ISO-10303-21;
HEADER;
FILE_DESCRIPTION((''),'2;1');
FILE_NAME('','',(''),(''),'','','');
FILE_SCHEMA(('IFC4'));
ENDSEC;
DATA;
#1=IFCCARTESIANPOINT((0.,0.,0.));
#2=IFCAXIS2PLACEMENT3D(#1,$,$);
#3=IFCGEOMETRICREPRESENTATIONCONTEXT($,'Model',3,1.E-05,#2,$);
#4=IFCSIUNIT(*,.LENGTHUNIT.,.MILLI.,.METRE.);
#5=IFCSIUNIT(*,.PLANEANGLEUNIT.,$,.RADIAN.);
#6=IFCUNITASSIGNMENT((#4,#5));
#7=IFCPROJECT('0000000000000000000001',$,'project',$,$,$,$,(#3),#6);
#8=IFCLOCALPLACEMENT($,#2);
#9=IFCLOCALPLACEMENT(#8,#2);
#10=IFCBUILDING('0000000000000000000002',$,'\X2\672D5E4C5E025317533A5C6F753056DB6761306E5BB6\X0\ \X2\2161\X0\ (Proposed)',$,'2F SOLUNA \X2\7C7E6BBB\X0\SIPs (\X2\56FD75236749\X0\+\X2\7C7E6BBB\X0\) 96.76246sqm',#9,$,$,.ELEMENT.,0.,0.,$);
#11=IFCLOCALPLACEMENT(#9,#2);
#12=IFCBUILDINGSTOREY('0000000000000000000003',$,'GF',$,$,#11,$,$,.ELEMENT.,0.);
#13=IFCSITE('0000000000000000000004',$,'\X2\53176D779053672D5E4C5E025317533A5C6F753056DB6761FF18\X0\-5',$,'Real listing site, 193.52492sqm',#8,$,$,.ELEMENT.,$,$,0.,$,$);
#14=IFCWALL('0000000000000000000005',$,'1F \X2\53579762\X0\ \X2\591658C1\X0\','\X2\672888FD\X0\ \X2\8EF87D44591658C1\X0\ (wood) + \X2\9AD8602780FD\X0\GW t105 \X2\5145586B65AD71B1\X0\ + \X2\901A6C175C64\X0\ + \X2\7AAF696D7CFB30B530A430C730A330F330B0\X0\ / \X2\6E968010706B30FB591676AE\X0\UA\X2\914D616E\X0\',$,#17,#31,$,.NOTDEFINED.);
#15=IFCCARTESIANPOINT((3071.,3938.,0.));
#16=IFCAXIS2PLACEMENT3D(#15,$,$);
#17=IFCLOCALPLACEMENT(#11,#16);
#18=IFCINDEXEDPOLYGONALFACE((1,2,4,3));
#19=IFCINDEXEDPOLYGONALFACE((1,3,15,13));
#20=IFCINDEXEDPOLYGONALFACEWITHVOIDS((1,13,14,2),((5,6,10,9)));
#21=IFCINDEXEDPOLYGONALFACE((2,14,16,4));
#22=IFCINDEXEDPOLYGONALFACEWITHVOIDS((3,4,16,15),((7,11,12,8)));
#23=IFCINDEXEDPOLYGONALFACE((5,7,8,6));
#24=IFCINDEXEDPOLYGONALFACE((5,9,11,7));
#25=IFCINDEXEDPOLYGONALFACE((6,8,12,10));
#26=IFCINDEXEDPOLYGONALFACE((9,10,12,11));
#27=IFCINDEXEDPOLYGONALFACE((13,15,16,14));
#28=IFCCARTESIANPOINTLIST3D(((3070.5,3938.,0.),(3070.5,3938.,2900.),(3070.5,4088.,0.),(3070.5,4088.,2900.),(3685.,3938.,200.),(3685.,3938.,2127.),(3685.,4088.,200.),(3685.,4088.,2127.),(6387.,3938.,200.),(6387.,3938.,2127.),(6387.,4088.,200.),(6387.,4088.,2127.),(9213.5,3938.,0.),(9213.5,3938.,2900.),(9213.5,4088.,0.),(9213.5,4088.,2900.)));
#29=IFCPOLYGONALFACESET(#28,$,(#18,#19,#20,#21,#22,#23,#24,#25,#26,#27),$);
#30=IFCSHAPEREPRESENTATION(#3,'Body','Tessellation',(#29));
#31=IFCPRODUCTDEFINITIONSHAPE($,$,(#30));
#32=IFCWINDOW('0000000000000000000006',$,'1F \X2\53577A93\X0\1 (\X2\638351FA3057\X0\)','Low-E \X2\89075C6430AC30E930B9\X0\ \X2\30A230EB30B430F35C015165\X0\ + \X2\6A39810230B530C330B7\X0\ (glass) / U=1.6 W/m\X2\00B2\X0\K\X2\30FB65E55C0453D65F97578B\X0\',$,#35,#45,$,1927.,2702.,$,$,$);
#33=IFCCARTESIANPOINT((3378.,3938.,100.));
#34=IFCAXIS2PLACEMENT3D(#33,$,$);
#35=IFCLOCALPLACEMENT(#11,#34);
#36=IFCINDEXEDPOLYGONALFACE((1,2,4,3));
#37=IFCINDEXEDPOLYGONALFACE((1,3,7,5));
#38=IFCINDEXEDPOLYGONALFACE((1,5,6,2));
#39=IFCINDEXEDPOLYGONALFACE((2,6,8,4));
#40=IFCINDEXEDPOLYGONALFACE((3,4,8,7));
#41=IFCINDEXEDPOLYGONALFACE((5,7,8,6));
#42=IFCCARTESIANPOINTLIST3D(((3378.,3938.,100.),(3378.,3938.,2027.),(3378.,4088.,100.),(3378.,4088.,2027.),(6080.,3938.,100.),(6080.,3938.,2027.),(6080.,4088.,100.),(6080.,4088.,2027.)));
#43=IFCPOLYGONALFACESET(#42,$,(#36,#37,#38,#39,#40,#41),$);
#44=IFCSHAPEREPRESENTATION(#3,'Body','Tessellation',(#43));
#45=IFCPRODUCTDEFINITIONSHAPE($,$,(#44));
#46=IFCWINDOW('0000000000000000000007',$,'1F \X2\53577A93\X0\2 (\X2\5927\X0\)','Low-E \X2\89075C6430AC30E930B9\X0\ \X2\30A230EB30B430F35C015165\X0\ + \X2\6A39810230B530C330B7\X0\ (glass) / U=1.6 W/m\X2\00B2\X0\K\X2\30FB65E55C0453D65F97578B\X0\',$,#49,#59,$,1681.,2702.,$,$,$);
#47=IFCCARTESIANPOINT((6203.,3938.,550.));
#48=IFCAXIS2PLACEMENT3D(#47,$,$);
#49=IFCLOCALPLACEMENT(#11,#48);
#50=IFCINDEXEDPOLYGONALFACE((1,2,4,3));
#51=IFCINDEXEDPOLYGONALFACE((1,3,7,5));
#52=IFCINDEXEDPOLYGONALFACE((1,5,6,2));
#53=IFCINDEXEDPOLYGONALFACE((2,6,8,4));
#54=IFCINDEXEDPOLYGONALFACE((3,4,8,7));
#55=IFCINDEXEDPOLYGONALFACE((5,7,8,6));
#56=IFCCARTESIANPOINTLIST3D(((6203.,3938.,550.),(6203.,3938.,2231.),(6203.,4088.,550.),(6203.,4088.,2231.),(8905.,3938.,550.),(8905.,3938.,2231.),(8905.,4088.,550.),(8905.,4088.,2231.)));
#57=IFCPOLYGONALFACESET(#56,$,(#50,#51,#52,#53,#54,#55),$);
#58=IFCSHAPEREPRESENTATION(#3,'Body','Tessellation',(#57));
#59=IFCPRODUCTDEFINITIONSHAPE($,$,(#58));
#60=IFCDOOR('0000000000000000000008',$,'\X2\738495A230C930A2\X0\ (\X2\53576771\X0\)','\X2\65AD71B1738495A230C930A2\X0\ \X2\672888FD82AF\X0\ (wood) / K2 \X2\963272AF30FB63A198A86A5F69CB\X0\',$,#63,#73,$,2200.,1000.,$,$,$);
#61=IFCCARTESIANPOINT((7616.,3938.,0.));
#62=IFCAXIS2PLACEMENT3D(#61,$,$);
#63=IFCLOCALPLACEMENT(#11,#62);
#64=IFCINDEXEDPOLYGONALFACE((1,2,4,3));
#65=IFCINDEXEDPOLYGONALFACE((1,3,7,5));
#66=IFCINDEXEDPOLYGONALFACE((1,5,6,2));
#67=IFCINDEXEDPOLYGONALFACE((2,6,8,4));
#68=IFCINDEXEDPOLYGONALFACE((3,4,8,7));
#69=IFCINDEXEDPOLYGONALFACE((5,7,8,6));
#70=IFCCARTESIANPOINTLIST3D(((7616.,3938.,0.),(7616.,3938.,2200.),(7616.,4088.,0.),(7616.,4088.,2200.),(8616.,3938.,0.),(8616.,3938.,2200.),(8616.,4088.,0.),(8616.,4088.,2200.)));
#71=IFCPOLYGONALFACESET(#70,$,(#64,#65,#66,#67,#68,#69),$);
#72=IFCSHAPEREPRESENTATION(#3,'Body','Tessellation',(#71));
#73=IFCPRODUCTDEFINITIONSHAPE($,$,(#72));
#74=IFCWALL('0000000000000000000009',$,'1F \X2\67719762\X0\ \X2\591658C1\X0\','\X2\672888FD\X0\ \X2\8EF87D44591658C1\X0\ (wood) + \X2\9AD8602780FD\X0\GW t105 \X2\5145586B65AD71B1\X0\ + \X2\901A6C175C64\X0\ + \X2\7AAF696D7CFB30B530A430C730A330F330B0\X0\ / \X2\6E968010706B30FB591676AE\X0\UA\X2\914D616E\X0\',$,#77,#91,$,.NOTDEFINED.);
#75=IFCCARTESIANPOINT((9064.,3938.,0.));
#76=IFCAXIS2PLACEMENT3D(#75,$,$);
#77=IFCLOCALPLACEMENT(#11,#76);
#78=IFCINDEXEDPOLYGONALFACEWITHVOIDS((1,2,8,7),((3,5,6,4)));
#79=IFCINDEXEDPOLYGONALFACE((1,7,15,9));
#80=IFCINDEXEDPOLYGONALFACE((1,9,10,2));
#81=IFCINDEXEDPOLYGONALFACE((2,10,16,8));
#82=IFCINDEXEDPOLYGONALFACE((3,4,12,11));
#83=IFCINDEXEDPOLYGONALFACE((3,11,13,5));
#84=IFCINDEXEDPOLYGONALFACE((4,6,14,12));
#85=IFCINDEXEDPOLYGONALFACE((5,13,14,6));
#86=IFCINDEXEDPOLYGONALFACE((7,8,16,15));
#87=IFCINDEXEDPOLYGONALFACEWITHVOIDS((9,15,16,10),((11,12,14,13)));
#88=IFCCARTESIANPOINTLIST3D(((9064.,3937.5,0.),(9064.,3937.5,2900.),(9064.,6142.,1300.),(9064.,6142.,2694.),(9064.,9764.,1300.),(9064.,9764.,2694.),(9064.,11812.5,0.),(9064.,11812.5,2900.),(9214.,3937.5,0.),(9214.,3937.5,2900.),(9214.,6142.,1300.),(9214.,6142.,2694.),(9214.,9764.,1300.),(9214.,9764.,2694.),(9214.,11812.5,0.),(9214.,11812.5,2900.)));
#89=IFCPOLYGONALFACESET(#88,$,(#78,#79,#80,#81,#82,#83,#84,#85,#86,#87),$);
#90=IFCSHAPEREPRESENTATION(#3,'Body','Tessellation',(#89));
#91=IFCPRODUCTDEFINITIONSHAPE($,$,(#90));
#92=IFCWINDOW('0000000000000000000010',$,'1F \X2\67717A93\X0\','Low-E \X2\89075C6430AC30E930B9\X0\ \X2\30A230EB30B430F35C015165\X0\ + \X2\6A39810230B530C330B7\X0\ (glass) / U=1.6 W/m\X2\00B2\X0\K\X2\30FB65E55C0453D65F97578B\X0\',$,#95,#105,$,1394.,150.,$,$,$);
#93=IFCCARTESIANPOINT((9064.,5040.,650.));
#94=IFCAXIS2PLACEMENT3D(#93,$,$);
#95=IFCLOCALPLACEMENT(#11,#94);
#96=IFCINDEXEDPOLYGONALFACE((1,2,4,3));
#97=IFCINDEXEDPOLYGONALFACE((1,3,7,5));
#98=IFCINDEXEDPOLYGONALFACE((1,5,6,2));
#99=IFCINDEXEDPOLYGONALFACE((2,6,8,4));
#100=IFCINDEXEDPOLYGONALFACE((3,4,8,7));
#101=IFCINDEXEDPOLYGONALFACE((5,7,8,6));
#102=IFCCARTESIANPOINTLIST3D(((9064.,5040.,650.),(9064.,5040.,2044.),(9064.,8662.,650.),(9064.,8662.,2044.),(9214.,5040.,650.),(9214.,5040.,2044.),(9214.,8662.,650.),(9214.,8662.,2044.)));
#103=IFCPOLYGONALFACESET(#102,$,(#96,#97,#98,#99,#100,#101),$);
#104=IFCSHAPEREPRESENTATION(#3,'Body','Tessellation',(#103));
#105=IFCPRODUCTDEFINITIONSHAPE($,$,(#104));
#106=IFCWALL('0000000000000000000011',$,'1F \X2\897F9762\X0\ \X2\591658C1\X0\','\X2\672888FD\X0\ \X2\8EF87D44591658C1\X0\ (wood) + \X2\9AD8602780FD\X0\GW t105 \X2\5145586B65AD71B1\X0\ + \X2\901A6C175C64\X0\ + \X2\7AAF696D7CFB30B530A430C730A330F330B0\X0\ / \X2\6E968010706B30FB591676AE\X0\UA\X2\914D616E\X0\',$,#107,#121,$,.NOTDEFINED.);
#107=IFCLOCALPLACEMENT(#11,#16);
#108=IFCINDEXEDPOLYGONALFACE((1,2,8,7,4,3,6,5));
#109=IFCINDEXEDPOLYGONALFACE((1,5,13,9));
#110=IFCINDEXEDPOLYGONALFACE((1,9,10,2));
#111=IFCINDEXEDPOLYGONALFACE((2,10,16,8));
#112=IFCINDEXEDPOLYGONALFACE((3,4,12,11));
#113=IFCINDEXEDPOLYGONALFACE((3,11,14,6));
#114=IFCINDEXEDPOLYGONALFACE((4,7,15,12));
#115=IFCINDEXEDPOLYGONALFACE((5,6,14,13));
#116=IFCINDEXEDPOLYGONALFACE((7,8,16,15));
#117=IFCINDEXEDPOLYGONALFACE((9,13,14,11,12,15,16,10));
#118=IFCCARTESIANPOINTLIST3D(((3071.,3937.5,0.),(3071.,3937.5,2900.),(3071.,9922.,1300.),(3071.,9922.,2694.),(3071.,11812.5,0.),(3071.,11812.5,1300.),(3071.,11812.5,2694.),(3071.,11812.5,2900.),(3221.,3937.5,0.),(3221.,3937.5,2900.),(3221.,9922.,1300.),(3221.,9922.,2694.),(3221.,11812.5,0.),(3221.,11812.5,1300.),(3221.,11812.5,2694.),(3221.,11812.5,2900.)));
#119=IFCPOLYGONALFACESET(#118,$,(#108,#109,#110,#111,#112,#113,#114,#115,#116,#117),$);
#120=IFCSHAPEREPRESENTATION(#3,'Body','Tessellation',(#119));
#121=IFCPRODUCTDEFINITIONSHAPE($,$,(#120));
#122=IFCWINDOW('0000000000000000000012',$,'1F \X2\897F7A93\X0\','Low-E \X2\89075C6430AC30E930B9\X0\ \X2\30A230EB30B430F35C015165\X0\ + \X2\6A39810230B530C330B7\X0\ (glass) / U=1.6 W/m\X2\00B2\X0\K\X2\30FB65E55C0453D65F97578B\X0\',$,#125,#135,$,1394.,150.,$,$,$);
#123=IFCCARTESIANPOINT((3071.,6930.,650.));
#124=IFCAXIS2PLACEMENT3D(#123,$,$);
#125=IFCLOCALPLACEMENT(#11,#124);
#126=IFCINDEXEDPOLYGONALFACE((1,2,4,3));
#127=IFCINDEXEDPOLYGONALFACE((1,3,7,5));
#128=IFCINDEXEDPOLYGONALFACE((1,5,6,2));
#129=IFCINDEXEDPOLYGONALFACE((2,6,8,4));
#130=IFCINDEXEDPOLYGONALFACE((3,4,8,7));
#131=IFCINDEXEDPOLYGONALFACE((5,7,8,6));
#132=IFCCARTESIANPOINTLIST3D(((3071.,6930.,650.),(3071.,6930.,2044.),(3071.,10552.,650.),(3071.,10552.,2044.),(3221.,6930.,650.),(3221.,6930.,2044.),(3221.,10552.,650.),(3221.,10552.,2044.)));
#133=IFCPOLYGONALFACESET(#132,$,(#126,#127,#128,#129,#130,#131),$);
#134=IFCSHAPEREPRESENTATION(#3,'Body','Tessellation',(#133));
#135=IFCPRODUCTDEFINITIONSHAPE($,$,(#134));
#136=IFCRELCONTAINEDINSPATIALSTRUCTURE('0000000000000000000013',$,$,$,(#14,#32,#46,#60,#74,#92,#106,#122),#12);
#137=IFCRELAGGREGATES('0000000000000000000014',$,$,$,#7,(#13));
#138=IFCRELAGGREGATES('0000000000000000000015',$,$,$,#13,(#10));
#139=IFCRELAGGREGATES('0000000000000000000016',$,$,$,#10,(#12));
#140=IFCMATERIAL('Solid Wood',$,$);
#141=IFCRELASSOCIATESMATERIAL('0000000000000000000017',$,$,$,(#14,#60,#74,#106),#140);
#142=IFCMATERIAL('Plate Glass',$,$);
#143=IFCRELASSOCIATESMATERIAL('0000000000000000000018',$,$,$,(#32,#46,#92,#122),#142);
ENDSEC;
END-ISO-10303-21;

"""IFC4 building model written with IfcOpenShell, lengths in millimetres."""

from ifc_helpers import new_model, si_unit, frame, frame_2d, origin, place, context, project, spatial, rectangle, extrude, material, element, fill, save


model = new_model("IFC4")

# Units and contexts
model_context = context("Model", 3, precision=1e-05, world=origin())
ifc_project = project(units=[si_unit("LENGTHUNIT", "METRE", prefix="MILLI"), si_unit("PLANEANGLEUNIT", "RADIAN")], contexts=[model_context])

# Site, building, storey
site_placement = place(None, origin())
site = spatial("IfcSite", under=ifc_project, at=site_placement, Name="北海道札幌市北区屯田四条８-5", ObjectType="Real listing site, 193.52492sqm", CompositionType="ELEMENT", RefElevation=0.0)
building_placement = place(site_placement, origin())
building = spatial("IfcBuilding", under=site, at=building_placement, Name="札幌市北区屯田四条の家 Ⅱ (Proposed)", ObjectType="2F SOLUNA 籾殻SIPs (国産杉+籾殻) 96.76246sqm", CompositionType="ELEMENT", ElevationOfRefHeight=0.0, ElevationOfTerrain=0.0)
storey_placement = place(building_placement, origin())
storey = spatial("IfcBuildingStorey", under=building, at=storey_placement, Name="GF", CompositionType="ELEMENT", Elevation=0.0)

# Shared definitions
ifc_material_1 = material(Name="Solid Wood")

# Wall, openings, windows, door
wall_1_placement = place(storey_placement, frame((3071.0, 3938.0, 0.0)))
wall_1 = element("IfcWall", 1, at=wall_1_placement, inside=storey, material=ifc_material_1, Name="1F 南面 外壁", Description="木製 軸組外壁 (wood) + 高性能GW t105 充填断熱 + 通気層 + 窯業系サイディング / 準耐火・外皮UA配慮", PredefinedType="NOTDEFINED", context=model_context, shape_type="SweptSolid", body=[
    extrude(rectangle(XDim=6143.0, YDim=150.0, at=frame_2d((3071.0, 75.0))), frame((3071.0, 3938.0, 0.0)), (0.0, 0.0, 1.0), 2900.0),
])
opening_1_placement = place(storey_placement, frame((3378.0, 3938.0, 100.0)))
opening_1 = element("IfcOpeningElement", 2, at=opening_1_placement, cuts=wall_1, PredefinedType="NOTDEFINED", context=model_context, shape_type="SweptSolid", body=[
    extrude(rectangle(XDim=2702.0, YDim=150.0, at=frame_2d((1351.0, 75.0))), frame((3378.0, 3938.0, 100.0)), (0.0, 0.0, 1.0), 1927.0),
])
opening_2_placement = place(storey_placement, frame((6203.0, 3938.0, 550.0)))
opening_2 = element("IfcOpeningElement", 3, at=opening_2_placement, cuts=wall_1, PredefinedType="NOTDEFINED", context=model_context, shape_type="SweptSolid", body=[
    extrude(rectangle(XDim=2702.0, YDim=150.0, at=frame_2d((1351.0, 75.0))), frame((6203.0, 3938.0, 550.0)), (0.0, 0.0, 1.0), 1681.0),
])
opening_3_placement = place(storey_placement, frame((7616.0, 3938.0, 0.0)))
opening_3 = element("IfcOpeningElement", 4, at=opening_3_placement, cuts=wall_1, PredefinedType="NOTDEFINED", context=model_context, shape_type="SweptSolid", body=[
    extrude(rectangle(XDim=1000.0, YDim=150.0, at=frame_2d((500.0, 75.0))), frame((7616.0, 3938.0, 0.0)), (0.0, 0.0, 1.0), 2200.0),
])
ifc_material_2 = material(Name="Plate Glass")
window_1_placement = place(storey_placement, frame((3378.0, 3938.0, 100.0)))
window_1 = element("IfcWindow", 5, at=window_1_placement, inside=storey, material=ifc_material_2, Name="1F 南窓1 (掃出し)", Description="Low-E 複層ガラス アルゴン封入 + 樹脂サッシ (glass) / U=1.6 W/m²K・日射取得型", OverallHeight=1927.0, OverallWidth=2702.0, context=model_context, shape_type="SweptSolid", body=[
    extrude(rectangle(XDim=2702.0, YDim=150.0, at=frame_2d((1351.0, 75.0))), frame((3378.0, 3938.0, 100.0)), (0.0, 0.0, 1.0), 1927.0),
])
fill(opening_1, window_1)
window_2_placement = place(storey_placement, frame((6203.0, 3938.0, 550.0)))
window_2 = element("IfcWindow", 6, at=window_2_placement, inside=storey, material=ifc_material_2, Name="1F 南窓2 (大)", Description="Low-E 複層ガラス アルゴン封入 + 樹脂サッシ (glass) / U=1.6 W/m²K・日射取得型", OverallHeight=1681.0, OverallWidth=2702.0, context=model_context, shape_type="SweptSolid", body=[
    extrude(rectangle(XDim=2702.0, YDim=150.0, at=frame_2d((1351.0, 75.0))), frame((6203.0, 3938.0, 550.0)), (0.0, 0.0, 1.0), 1681.0),
])
fill(opening_2, window_2)
door_placement = place(storey_placement, frame((7616.0, 3938.0, 0.0)))
door = element("IfcDoor", 7, at=door_placement, inside=storey, material=ifc_material_1, Name="玄関ドア (南東)", Description="断熱玄関ドア 木製芯 (wood) / K2 防犯・採風機構", OverallHeight=2200.0, OverallWidth=1000.0, context=model_context, shape_type="SweptSolid", body=[
    extrude(rectangle(XDim=1000.0, YDim=150.0, at=frame_2d((500.0, 75.0))), frame((7616.0, 3938.0, 0.0)), (0.0, 0.0, 1.0), 2200.0),
])
fill(opening_3, door)

# Walls, openings, windows
wall_2_placement = place(storey_placement, frame((9064.0, 3938.0, 0.0)))
wall_2 = element("IfcWall", 8, at=wall_2_placement, inside=storey, material=ifc_material_1, Name="1F 東面 外壁", Description="木製 軸組外壁 (wood) + 高性能GW t105 充填断熱 + 通気層 + 窯業系サイディング / 準耐火・外皮UA配慮", PredefinedType="NOTDEFINED", context=model_context, shape_type="SweptSolid", body=[
    extrude(rectangle(XDim=150.0, YDim=7875.0, at=frame_2d((75.0, 3937.0))), frame((9064.0, 3938.0, 0.0)), (0.0, 0.0, 1.0), 2900.0),
])
opening_4_placement = place(storey_placement, frame((9064.0, 5040.0, 650.0)))
opening_4 = element("IfcOpeningElement", 9, at=opening_4_placement, cuts=wall_2, PredefinedType="NOTDEFINED", context=model_context, shape_type="SweptSolid", body=[
    extrude(rectangle(XDim=150.0, YDim=3622.0, at=frame_2d((75.0, 1811.0))), frame((9064.0, 5040.0, 650.0)), (0.0, 0.0, 1.0), 1394.0),
])
window_3_placement = place(storey_placement, frame((9064.0, 5040.0, 650.0)))
window_3 = element("IfcWindow", 10, at=window_3_placement, inside=storey, material=ifc_material_2, Name="1F 東窓", Description="Low-E 複層ガラス アルゴン封入 + 樹脂サッシ (glass) / U=1.6 W/m²K・日射取得型", OverallHeight=1394.0, OverallWidth=150.0, context=model_context, shape_type="SweptSolid", body=[
    extrude(rectangle(XDim=150.0, YDim=3622.0, at=frame_2d((75.0, 1811.0))), frame((9064.0, 5040.0, 650.0)), (0.0, 0.0, 1.0), 1394.0),
])
fill(opening_4, window_3)
wall_3_placement = place(storey_placement, frame((3071.0, 3938.0, 0.0)))
wall_3 = element("IfcWall", 11, at=wall_3_placement, inside=storey, material=ifc_material_1, Name="1F 西面 外壁", Description="木製 軸組外壁 (wood) + 高性能GW t105 充填断熱 + 通気層 + 窯業系サイディング / 準耐火・外皮UA配慮", PredefinedType="NOTDEFINED", context=model_context, shape_type="SweptSolid", body=[
    extrude(rectangle(XDim=150.0, YDim=7875.0, at=frame_2d((75.0, 3937.0))), frame((3071.0, 3938.0, 0.0)), (0.0, 0.0, 1.0), 2900.0),
])
opening_5_placement = place(storey_placement, frame((3071.0, 6930.0, 650.0)))
opening_5 = element("IfcOpeningElement", 12, at=opening_5_placement, cuts=wall_3, PredefinedType="NOTDEFINED", context=model_context, shape_type="SweptSolid", body=[
    extrude(rectangle(XDim=150.0, YDim=3622.0, at=frame_2d((75.0, 1811.0))), frame((3071.0, 6930.0, 650.0)), (0.0, 0.0, 1.0), 1394.0),
])
window_4_placement = place(storey_placement, frame((3071.0, 6930.0, 650.0)))
window_4 = element("IfcWindow", 13, at=window_4_placement, inside=storey, material=ifc_material_2, Name="1F 西窓", Description="Low-E 複層ガラス アルゴン封入 + 樹脂サッシ (glass) / U=1.6 W/m²K・日射取得型", OverallHeight=1394.0, OverallWidth=150.0, context=model_context, shape_type="SweptSolid", body=[
    extrude(rectangle(XDim=150.0, YDim=3622.0, at=frame_2d((75.0, 1811.0))), frame((3071.0, 6930.0, 650.0)), (0.0, 0.0, 1.0), 1394.0),
])
fill(opening_5, window_4)

save(model, "model.ifc")
